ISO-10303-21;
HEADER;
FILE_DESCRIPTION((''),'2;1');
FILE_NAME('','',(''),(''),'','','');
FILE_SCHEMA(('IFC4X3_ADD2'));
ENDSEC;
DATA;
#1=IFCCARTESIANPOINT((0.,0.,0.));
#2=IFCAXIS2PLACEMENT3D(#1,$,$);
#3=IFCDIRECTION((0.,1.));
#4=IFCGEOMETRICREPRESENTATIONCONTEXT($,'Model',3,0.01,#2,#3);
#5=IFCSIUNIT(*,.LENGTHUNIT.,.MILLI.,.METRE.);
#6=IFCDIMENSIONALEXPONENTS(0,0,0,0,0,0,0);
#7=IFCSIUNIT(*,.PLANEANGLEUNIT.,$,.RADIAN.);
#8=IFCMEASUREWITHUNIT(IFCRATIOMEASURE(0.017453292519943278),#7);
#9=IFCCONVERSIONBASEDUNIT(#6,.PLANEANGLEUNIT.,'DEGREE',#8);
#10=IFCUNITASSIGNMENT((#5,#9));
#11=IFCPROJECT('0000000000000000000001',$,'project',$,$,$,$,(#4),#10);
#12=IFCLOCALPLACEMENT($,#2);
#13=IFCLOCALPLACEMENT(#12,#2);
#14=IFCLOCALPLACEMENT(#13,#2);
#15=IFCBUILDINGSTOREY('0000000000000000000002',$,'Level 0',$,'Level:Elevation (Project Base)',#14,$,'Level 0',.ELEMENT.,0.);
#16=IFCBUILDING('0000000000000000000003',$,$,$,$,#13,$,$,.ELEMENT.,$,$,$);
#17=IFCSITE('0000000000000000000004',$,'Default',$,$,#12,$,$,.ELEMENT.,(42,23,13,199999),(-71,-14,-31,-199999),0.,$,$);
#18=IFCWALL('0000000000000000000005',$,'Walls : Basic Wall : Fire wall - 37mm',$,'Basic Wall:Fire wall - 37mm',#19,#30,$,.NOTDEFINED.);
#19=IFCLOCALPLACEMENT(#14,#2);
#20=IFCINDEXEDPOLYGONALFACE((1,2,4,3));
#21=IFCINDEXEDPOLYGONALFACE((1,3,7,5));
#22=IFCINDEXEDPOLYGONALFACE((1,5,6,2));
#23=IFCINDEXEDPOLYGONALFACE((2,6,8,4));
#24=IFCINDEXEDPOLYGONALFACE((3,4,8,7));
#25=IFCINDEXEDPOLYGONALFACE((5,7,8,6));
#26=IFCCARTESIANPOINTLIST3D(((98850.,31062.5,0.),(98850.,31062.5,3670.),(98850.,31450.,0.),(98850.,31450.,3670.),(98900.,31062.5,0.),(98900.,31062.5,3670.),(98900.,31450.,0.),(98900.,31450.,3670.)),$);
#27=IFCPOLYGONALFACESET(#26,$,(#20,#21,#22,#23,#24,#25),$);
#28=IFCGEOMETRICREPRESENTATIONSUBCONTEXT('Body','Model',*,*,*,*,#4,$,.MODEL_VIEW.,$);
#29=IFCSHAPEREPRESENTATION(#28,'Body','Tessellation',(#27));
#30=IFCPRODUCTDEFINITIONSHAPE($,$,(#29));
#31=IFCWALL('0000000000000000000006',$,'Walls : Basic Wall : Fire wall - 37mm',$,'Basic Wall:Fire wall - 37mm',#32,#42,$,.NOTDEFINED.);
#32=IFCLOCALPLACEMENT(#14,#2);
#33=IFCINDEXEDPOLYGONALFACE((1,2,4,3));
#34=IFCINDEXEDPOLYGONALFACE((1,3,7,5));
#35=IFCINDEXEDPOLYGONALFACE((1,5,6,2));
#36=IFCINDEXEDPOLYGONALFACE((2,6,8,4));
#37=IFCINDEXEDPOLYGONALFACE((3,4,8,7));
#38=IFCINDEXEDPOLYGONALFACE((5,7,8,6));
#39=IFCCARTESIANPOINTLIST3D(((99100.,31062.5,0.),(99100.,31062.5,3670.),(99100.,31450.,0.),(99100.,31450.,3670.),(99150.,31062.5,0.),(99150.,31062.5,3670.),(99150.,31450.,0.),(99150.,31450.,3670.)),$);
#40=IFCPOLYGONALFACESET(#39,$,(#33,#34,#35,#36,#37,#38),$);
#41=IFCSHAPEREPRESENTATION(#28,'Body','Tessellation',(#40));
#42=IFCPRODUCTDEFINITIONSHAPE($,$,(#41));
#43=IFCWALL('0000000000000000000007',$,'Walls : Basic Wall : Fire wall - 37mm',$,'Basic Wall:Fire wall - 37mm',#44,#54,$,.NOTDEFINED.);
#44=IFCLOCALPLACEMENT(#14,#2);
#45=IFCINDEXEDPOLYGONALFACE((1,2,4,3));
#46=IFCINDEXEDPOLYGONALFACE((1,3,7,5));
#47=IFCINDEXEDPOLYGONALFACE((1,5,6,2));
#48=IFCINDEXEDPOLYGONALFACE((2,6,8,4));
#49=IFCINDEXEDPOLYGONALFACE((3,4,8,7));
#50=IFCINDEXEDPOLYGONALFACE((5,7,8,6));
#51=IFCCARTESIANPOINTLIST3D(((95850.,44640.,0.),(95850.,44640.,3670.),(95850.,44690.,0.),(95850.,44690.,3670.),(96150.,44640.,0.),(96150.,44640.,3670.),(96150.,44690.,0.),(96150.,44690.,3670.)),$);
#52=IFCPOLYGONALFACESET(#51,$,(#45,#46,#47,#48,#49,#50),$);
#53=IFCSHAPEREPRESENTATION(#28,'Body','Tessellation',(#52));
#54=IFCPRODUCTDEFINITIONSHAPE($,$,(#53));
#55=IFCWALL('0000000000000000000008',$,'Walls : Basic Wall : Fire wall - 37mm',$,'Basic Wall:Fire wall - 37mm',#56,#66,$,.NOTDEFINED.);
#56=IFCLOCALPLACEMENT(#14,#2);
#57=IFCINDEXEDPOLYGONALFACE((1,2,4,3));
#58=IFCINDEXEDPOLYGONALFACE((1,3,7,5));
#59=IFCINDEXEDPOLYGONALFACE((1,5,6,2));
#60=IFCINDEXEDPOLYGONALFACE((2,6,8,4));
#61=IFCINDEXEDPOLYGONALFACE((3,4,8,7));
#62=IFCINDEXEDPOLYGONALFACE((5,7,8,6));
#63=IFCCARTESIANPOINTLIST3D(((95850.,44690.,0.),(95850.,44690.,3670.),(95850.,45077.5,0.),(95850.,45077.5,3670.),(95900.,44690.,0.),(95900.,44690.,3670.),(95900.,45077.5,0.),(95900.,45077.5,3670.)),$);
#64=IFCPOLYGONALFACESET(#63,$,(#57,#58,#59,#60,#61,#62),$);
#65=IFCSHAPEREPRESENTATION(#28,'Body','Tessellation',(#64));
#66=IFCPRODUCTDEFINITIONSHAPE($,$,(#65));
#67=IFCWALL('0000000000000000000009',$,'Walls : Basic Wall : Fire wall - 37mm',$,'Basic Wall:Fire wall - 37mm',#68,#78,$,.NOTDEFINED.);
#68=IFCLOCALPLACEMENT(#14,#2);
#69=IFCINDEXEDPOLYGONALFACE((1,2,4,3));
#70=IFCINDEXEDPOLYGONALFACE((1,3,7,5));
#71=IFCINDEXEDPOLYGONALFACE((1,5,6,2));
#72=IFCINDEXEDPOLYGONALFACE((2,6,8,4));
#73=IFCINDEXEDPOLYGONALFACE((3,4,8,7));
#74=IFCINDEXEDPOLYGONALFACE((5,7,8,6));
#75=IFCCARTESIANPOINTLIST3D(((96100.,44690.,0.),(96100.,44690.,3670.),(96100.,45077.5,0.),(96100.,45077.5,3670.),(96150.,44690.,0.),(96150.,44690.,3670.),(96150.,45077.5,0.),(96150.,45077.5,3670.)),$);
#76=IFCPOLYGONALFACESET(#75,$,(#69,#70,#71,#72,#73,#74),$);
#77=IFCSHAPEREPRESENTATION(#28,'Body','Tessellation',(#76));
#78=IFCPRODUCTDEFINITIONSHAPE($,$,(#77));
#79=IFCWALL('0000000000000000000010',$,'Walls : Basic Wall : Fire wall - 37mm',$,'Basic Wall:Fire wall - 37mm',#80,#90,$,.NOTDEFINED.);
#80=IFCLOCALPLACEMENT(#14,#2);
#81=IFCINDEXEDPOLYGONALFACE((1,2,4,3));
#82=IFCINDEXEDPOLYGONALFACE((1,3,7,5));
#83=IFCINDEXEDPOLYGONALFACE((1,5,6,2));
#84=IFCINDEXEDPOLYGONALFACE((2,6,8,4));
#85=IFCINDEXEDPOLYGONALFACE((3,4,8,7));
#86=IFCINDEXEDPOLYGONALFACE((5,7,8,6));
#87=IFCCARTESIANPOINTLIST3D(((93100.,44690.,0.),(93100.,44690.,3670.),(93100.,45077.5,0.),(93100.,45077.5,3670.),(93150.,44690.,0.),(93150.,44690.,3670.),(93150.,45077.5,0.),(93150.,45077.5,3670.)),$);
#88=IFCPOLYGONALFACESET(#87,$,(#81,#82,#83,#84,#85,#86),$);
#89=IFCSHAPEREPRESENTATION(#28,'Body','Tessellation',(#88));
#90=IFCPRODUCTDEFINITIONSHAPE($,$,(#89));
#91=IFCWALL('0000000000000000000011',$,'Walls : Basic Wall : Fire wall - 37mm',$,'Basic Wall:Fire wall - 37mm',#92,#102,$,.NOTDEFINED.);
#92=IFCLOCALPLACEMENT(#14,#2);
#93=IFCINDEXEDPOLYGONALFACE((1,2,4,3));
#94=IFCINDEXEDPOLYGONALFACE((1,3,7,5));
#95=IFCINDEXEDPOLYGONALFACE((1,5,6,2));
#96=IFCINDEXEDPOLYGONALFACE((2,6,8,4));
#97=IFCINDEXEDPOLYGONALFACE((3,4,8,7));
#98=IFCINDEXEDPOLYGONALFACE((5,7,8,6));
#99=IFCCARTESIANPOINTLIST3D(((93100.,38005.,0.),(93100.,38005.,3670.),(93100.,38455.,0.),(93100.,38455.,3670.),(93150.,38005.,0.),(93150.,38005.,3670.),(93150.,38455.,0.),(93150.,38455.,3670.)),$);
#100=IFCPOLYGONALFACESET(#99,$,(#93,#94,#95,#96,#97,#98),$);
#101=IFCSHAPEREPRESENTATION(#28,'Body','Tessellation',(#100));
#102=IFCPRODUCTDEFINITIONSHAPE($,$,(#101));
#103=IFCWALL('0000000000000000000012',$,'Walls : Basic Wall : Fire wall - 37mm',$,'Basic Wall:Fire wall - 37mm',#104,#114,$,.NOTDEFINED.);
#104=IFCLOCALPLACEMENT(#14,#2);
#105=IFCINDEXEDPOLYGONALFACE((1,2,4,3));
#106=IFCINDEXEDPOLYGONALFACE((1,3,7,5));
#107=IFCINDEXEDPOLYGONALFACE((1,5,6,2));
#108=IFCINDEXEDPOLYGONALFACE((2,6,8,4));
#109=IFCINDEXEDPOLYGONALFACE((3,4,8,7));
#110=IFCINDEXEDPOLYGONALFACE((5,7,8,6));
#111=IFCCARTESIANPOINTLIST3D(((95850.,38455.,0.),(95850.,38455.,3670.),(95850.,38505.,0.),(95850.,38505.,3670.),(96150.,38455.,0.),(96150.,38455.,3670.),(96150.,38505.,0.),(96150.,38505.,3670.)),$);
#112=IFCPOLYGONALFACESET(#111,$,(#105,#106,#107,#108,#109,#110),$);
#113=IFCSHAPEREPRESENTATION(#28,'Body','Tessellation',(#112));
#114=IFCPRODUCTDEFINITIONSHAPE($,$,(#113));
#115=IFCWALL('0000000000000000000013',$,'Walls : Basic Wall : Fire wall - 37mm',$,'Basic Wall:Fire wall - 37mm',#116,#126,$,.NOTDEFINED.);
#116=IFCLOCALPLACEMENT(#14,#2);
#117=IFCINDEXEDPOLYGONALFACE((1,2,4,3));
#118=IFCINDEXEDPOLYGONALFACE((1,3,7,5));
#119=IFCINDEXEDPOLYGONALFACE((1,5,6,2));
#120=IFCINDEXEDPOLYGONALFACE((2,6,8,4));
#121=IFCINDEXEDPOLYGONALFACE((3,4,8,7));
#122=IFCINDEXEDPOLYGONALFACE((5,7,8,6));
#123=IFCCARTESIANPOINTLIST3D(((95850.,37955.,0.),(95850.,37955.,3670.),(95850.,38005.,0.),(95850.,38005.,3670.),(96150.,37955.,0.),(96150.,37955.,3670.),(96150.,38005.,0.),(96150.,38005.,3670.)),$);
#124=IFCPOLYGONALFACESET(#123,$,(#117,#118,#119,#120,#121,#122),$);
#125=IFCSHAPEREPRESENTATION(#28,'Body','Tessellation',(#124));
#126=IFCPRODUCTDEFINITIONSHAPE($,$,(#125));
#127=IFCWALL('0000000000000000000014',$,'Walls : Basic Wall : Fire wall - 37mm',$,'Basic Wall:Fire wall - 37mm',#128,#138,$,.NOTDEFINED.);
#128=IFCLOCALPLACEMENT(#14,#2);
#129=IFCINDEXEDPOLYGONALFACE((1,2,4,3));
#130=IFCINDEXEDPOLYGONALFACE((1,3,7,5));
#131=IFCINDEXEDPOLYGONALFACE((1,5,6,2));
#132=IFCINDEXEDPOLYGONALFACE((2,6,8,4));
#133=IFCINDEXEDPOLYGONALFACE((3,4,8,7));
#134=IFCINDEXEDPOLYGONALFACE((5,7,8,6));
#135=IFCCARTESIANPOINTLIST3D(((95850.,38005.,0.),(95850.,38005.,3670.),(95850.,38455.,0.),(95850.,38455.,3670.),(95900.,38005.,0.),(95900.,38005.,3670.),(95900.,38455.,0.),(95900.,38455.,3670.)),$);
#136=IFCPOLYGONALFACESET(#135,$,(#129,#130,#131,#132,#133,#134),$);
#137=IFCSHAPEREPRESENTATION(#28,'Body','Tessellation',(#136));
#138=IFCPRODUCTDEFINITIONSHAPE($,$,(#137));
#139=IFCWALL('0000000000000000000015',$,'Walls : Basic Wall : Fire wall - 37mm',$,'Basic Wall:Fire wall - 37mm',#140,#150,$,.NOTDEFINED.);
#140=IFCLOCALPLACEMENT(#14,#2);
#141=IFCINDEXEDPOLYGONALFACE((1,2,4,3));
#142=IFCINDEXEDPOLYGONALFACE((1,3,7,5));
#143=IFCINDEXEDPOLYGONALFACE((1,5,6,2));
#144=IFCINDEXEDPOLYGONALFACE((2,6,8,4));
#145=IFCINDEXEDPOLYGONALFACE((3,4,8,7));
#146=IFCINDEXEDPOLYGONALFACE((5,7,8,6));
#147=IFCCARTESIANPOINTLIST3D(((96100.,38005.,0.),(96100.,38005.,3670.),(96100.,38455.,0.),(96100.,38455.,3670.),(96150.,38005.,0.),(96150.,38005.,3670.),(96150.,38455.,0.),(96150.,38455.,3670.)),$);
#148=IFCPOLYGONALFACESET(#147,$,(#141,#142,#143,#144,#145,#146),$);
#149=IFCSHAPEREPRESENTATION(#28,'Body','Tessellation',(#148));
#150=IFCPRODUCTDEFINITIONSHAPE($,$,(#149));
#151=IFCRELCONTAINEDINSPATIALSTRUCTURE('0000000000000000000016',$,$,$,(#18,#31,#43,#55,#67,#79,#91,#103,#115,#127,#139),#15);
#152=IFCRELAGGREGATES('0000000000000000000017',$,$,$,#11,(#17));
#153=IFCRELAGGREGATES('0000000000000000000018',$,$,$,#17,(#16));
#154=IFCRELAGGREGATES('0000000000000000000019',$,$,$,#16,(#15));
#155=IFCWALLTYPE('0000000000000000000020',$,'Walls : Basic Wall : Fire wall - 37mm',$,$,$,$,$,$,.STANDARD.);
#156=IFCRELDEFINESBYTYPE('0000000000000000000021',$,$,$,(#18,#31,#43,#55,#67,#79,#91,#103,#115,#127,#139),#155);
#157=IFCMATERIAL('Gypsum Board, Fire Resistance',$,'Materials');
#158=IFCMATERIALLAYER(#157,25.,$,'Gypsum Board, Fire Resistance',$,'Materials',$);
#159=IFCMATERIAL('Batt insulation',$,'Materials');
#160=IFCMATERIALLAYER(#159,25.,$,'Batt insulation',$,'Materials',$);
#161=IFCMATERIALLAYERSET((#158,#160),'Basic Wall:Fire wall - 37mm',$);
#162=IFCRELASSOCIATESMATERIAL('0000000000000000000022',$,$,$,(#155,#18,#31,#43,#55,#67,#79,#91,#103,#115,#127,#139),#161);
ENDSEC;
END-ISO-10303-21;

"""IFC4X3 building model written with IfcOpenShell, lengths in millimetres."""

from ifc_helpers import new_model, entity, si_unit, converted_unit, direction, frame, frame_2d, origin, place, context, subcontext, project, spatial, rectangle, extrude, material, layer, layer_set, type_object, element, save


model = new_model("IFC4X3")

# Units and contexts
model_context = context("Model", 3, precision=0.01, world=origin(), true_north=direction((0.0, 1.0)))
body_context = subcontext(model_context, "Body", "Model", "MODEL_VIEW")
ifc_project = project(units=[si_unit("LENGTHUNIT", "METRE", prefix="MILLI"), converted_unit("PLANEANGLEUNIT", "DEGREE", entity("IfcRatioMeasure", 0.017453292519943278), si_unit("PLANEANGLEUNIT", "RADIAN"), dimensions=[0, 0, 0, 0, 0, 0, 0])], contexts=[model_context])

# Site, building, storey
site_placement = place(None, origin())
site = spatial("IfcSite", under=ifc_project, at=site_placement, Name="Default", CompositionType="ELEMENT", RefLatitude=(42, 23, 13, 199999), RefLongitude=(-71, -14, -31, -199999), RefElevation=0.0)
building_placement = place(site_placement, origin())
building = spatial("IfcBuilding", under=site, at=building_placement, CompositionType="ELEMENT")
storey_placement = place(building_placement, origin())
storey = spatial("IfcBuildingStorey", under=building, at=storey_placement, Name="Level 0", ObjectType="Level:Elevation (Project Base)", LongName="Level 0", CompositionType="ELEMENT", Elevation=0.0)

# Walls
ifc_material_1 = material(Name="Gypsum Board, Fire Resistance", Category="Materials")
ifc_layer_1 = layer(ifc_material_1, 25.0, Name="Gypsum Board, Fire Resistance", Category="Materials")
ifc_material_2 = material(Name="Batt insulation", Category="Materials")
ifc_layer_2 = layer(ifc_material_2, 25.0, Name="Batt insulation", Category="Materials")
ifc_layer_set_1 = layer_set([ifc_layer_1, ifc_layer_2], Name="Basic Wall:Fire wall - 37mm")
wall_type_1 = type_object("IfcWallType", Name="Walls : Basic Wall : Fire wall - 37mm", PredefinedType="STANDARD", material=ifc_layer_set_1)
for number, where, z_axis, x_axis, name in (
    (1, (98875.0, 31450.0, 0.0), (0.0, 0.0, 1.0), (0.0, -1.0, 0.0), "Walls : Basic Wall : Fire wall - 37mm"),
    (2, (99125.0, 31450.0, 0.0), (0.0, 0.0, 1.0), (0.0, -1.0, 0.0), "Walls : Basic Wall : Fire wall - 37mm"),
):
    element("IfcWall", number, at=place(storey_placement, frame(where, z_axis=z_axis, x_axis=x_axis)), inside=storey, type_object=wall_type_1, material=ifc_layer_set_1, Name=name, ObjectType="Basic Wall:Fire wall - 37mm", PredefinedType="NOTDEFINED", context=body_context, shape_type="SweptSolid", body=[
        extrude(rectangle(XDim=387.5, YDim=50.0, at=frame_2d((193.8, 0.0), x_axis=(-1.0, 0.0))), origin(), (0.0, 0.0, 1.0), 3670.0),
    ])
wall_1_placement = place(storey_placement, frame((95850.0, 44665.0, 0.0)))
element("IfcWall", 3, at=wall_1_placement, inside=storey, type_object=wall_type_1, material=ifc_layer_set_1, Name="Walls : Basic Wall : Fire wall - 37mm", ObjectType="Basic Wall:Fire wall - 37mm", PredefinedType="NOTDEFINED", context=body_context, shape_type="SweptSolid", body=[
    extrude(rectangle(XDim=300.0, YDim=50.0, at=frame_2d((150.0, 0.0), x_axis=(-1.0, 0.0))), origin(), (0.0, 0.0, 1.0), 3670.0),
])
for number, where, z_axis, x_axis, name in (
    (4, (95875.0, 45077.5, 0.0), (0.0, 0.0, 1.0), (0.0, -1.0, 0.0), "Walls : Basic Wall : Fire wall - 37mm"),
    (5, (96125.0, 45077.5, 0.0), (0.0, 0.0, 1.0), (0.0, -1.0, 0.0), "Walls : Basic Wall : Fire wall - 37mm"),
    (6, (93125.0, 45077.5, 0.0), (0.0, 0.0, 1.0), (0.0, -1.0, 0.0), "Walls : Basic Wall : Fire wall - 37mm"),
):
    element("IfcWall", number, at=place(storey_placement, frame(where, z_axis=z_axis, x_axis=x_axis)), inside=storey, type_object=wall_type_1, material=ifc_layer_set_1, Name=name, ObjectType="Basic Wall:Fire wall - 37mm", PredefinedType="NOTDEFINED", context=body_context, shape_type="SweptSolid", body=[
        extrude(rectangle(XDim=387.5, YDim=50.0, at=frame_2d((193.7, 0.0), x_axis=(-1.0, 0.0))), origin(), (0.0, 0.0, 1.0), 3670.0),
    ])
wall_2_placement = place(storey_placement, frame((93125.0, 38455.0, 0.0), z_axis=(0.0, 0.0, 1.0), x_axis=(0.0, -1.0, 0.0)))
element("IfcWall", 7, at=wall_2_placement, inside=storey, type_object=wall_type_1, material=ifc_layer_set_1, Name="Walls : Basic Wall : Fire wall - 37mm", ObjectType="Basic Wall:Fire wall - 37mm", PredefinedType="NOTDEFINED", context=body_context, shape_type="SweptSolid", body=[
    extrude(rectangle(XDim=450.0, YDim=50.0, at=frame_2d((225.0, 0.0), x_axis=(-1.0, 0.0))), origin(), (0.0, 0.0, 1.0), 3670.0),
])
wall_3_placement = place(storey_placement, frame((95850.0, 38480.0, 0.0)))
element("IfcWall", 8, at=wall_3_placement, inside=storey, type_object=wall_type_1, material=ifc_layer_set_1, Name="Walls : Basic Wall : Fire wall - 37mm", ObjectType="Basic Wall:Fire wall - 37mm", PredefinedType="NOTDEFINED", context=body_context, shape_type="SweptSolid", body=[
    extrude(rectangle(XDim=300.0, YDim=50.0, at=frame_2d((150.0, 0.0), x_axis=(-1.0, 0.0))), origin(), (0.0, 0.0, 1.0), 3670.0),
])
wall_4_placement = place(storey_placement, frame((95850.0, 37980.0, 0.0)))
element("IfcWall", 9, at=wall_4_placement, inside=storey, type_object=wall_type_1, material=ifc_layer_set_1, Name="Walls : Basic Wall : Fire wall - 37mm", ObjectType="Basic Wall:Fire wall - 37mm", PredefinedType="NOTDEFINED", context=body_context, shape_type="SweptSolid", body=[
    extrude(rectangle(XDim=300.0, YDim=50.0, at=frame_2d((150.0, 0.0), x_axis=(-1.0, 0.0))), origin(), (0.0, 0.0, 1.0), 3670.0),
])
for number, where, z_axis, x_axis, name in (
    (10, (95875.0, 38455.0, 0.0), (0.0, 0.0, 1.0), (0.0, -1.0, 0.0), "Walls : Basic Wall : Fire wall - 37mm"),
    (11, (96125.0, 38455.0, 0.0), (0.0, 0.0, 1.0), (0.0, -1.0, 0.0), "Walls : Basic Wall : Fire wall - 37mm"),
):
    element("IfcWall", number, at=place(storey_placement, frame(where, z_axis=z_axis, x_axis=x_axis)), inside=storey, type_object=wall_type_1, material=ifc_layer_set_1, Name=name, ObjectType="Basic Wall:Fire wall - 37mm", PredefinedType="NOTDEFINED", context=body_context, shape_type="SweptSolid", body=[
        extrude(rectangle(XDim=450.0, YDim=50.0, at=frame_2d((225.0, 0.0), x_axis=(-1.0, 0.0))), origin(), (0.0, 0.0, 1.0), 3670.0),
    ])

save(model, "model.ifc")
